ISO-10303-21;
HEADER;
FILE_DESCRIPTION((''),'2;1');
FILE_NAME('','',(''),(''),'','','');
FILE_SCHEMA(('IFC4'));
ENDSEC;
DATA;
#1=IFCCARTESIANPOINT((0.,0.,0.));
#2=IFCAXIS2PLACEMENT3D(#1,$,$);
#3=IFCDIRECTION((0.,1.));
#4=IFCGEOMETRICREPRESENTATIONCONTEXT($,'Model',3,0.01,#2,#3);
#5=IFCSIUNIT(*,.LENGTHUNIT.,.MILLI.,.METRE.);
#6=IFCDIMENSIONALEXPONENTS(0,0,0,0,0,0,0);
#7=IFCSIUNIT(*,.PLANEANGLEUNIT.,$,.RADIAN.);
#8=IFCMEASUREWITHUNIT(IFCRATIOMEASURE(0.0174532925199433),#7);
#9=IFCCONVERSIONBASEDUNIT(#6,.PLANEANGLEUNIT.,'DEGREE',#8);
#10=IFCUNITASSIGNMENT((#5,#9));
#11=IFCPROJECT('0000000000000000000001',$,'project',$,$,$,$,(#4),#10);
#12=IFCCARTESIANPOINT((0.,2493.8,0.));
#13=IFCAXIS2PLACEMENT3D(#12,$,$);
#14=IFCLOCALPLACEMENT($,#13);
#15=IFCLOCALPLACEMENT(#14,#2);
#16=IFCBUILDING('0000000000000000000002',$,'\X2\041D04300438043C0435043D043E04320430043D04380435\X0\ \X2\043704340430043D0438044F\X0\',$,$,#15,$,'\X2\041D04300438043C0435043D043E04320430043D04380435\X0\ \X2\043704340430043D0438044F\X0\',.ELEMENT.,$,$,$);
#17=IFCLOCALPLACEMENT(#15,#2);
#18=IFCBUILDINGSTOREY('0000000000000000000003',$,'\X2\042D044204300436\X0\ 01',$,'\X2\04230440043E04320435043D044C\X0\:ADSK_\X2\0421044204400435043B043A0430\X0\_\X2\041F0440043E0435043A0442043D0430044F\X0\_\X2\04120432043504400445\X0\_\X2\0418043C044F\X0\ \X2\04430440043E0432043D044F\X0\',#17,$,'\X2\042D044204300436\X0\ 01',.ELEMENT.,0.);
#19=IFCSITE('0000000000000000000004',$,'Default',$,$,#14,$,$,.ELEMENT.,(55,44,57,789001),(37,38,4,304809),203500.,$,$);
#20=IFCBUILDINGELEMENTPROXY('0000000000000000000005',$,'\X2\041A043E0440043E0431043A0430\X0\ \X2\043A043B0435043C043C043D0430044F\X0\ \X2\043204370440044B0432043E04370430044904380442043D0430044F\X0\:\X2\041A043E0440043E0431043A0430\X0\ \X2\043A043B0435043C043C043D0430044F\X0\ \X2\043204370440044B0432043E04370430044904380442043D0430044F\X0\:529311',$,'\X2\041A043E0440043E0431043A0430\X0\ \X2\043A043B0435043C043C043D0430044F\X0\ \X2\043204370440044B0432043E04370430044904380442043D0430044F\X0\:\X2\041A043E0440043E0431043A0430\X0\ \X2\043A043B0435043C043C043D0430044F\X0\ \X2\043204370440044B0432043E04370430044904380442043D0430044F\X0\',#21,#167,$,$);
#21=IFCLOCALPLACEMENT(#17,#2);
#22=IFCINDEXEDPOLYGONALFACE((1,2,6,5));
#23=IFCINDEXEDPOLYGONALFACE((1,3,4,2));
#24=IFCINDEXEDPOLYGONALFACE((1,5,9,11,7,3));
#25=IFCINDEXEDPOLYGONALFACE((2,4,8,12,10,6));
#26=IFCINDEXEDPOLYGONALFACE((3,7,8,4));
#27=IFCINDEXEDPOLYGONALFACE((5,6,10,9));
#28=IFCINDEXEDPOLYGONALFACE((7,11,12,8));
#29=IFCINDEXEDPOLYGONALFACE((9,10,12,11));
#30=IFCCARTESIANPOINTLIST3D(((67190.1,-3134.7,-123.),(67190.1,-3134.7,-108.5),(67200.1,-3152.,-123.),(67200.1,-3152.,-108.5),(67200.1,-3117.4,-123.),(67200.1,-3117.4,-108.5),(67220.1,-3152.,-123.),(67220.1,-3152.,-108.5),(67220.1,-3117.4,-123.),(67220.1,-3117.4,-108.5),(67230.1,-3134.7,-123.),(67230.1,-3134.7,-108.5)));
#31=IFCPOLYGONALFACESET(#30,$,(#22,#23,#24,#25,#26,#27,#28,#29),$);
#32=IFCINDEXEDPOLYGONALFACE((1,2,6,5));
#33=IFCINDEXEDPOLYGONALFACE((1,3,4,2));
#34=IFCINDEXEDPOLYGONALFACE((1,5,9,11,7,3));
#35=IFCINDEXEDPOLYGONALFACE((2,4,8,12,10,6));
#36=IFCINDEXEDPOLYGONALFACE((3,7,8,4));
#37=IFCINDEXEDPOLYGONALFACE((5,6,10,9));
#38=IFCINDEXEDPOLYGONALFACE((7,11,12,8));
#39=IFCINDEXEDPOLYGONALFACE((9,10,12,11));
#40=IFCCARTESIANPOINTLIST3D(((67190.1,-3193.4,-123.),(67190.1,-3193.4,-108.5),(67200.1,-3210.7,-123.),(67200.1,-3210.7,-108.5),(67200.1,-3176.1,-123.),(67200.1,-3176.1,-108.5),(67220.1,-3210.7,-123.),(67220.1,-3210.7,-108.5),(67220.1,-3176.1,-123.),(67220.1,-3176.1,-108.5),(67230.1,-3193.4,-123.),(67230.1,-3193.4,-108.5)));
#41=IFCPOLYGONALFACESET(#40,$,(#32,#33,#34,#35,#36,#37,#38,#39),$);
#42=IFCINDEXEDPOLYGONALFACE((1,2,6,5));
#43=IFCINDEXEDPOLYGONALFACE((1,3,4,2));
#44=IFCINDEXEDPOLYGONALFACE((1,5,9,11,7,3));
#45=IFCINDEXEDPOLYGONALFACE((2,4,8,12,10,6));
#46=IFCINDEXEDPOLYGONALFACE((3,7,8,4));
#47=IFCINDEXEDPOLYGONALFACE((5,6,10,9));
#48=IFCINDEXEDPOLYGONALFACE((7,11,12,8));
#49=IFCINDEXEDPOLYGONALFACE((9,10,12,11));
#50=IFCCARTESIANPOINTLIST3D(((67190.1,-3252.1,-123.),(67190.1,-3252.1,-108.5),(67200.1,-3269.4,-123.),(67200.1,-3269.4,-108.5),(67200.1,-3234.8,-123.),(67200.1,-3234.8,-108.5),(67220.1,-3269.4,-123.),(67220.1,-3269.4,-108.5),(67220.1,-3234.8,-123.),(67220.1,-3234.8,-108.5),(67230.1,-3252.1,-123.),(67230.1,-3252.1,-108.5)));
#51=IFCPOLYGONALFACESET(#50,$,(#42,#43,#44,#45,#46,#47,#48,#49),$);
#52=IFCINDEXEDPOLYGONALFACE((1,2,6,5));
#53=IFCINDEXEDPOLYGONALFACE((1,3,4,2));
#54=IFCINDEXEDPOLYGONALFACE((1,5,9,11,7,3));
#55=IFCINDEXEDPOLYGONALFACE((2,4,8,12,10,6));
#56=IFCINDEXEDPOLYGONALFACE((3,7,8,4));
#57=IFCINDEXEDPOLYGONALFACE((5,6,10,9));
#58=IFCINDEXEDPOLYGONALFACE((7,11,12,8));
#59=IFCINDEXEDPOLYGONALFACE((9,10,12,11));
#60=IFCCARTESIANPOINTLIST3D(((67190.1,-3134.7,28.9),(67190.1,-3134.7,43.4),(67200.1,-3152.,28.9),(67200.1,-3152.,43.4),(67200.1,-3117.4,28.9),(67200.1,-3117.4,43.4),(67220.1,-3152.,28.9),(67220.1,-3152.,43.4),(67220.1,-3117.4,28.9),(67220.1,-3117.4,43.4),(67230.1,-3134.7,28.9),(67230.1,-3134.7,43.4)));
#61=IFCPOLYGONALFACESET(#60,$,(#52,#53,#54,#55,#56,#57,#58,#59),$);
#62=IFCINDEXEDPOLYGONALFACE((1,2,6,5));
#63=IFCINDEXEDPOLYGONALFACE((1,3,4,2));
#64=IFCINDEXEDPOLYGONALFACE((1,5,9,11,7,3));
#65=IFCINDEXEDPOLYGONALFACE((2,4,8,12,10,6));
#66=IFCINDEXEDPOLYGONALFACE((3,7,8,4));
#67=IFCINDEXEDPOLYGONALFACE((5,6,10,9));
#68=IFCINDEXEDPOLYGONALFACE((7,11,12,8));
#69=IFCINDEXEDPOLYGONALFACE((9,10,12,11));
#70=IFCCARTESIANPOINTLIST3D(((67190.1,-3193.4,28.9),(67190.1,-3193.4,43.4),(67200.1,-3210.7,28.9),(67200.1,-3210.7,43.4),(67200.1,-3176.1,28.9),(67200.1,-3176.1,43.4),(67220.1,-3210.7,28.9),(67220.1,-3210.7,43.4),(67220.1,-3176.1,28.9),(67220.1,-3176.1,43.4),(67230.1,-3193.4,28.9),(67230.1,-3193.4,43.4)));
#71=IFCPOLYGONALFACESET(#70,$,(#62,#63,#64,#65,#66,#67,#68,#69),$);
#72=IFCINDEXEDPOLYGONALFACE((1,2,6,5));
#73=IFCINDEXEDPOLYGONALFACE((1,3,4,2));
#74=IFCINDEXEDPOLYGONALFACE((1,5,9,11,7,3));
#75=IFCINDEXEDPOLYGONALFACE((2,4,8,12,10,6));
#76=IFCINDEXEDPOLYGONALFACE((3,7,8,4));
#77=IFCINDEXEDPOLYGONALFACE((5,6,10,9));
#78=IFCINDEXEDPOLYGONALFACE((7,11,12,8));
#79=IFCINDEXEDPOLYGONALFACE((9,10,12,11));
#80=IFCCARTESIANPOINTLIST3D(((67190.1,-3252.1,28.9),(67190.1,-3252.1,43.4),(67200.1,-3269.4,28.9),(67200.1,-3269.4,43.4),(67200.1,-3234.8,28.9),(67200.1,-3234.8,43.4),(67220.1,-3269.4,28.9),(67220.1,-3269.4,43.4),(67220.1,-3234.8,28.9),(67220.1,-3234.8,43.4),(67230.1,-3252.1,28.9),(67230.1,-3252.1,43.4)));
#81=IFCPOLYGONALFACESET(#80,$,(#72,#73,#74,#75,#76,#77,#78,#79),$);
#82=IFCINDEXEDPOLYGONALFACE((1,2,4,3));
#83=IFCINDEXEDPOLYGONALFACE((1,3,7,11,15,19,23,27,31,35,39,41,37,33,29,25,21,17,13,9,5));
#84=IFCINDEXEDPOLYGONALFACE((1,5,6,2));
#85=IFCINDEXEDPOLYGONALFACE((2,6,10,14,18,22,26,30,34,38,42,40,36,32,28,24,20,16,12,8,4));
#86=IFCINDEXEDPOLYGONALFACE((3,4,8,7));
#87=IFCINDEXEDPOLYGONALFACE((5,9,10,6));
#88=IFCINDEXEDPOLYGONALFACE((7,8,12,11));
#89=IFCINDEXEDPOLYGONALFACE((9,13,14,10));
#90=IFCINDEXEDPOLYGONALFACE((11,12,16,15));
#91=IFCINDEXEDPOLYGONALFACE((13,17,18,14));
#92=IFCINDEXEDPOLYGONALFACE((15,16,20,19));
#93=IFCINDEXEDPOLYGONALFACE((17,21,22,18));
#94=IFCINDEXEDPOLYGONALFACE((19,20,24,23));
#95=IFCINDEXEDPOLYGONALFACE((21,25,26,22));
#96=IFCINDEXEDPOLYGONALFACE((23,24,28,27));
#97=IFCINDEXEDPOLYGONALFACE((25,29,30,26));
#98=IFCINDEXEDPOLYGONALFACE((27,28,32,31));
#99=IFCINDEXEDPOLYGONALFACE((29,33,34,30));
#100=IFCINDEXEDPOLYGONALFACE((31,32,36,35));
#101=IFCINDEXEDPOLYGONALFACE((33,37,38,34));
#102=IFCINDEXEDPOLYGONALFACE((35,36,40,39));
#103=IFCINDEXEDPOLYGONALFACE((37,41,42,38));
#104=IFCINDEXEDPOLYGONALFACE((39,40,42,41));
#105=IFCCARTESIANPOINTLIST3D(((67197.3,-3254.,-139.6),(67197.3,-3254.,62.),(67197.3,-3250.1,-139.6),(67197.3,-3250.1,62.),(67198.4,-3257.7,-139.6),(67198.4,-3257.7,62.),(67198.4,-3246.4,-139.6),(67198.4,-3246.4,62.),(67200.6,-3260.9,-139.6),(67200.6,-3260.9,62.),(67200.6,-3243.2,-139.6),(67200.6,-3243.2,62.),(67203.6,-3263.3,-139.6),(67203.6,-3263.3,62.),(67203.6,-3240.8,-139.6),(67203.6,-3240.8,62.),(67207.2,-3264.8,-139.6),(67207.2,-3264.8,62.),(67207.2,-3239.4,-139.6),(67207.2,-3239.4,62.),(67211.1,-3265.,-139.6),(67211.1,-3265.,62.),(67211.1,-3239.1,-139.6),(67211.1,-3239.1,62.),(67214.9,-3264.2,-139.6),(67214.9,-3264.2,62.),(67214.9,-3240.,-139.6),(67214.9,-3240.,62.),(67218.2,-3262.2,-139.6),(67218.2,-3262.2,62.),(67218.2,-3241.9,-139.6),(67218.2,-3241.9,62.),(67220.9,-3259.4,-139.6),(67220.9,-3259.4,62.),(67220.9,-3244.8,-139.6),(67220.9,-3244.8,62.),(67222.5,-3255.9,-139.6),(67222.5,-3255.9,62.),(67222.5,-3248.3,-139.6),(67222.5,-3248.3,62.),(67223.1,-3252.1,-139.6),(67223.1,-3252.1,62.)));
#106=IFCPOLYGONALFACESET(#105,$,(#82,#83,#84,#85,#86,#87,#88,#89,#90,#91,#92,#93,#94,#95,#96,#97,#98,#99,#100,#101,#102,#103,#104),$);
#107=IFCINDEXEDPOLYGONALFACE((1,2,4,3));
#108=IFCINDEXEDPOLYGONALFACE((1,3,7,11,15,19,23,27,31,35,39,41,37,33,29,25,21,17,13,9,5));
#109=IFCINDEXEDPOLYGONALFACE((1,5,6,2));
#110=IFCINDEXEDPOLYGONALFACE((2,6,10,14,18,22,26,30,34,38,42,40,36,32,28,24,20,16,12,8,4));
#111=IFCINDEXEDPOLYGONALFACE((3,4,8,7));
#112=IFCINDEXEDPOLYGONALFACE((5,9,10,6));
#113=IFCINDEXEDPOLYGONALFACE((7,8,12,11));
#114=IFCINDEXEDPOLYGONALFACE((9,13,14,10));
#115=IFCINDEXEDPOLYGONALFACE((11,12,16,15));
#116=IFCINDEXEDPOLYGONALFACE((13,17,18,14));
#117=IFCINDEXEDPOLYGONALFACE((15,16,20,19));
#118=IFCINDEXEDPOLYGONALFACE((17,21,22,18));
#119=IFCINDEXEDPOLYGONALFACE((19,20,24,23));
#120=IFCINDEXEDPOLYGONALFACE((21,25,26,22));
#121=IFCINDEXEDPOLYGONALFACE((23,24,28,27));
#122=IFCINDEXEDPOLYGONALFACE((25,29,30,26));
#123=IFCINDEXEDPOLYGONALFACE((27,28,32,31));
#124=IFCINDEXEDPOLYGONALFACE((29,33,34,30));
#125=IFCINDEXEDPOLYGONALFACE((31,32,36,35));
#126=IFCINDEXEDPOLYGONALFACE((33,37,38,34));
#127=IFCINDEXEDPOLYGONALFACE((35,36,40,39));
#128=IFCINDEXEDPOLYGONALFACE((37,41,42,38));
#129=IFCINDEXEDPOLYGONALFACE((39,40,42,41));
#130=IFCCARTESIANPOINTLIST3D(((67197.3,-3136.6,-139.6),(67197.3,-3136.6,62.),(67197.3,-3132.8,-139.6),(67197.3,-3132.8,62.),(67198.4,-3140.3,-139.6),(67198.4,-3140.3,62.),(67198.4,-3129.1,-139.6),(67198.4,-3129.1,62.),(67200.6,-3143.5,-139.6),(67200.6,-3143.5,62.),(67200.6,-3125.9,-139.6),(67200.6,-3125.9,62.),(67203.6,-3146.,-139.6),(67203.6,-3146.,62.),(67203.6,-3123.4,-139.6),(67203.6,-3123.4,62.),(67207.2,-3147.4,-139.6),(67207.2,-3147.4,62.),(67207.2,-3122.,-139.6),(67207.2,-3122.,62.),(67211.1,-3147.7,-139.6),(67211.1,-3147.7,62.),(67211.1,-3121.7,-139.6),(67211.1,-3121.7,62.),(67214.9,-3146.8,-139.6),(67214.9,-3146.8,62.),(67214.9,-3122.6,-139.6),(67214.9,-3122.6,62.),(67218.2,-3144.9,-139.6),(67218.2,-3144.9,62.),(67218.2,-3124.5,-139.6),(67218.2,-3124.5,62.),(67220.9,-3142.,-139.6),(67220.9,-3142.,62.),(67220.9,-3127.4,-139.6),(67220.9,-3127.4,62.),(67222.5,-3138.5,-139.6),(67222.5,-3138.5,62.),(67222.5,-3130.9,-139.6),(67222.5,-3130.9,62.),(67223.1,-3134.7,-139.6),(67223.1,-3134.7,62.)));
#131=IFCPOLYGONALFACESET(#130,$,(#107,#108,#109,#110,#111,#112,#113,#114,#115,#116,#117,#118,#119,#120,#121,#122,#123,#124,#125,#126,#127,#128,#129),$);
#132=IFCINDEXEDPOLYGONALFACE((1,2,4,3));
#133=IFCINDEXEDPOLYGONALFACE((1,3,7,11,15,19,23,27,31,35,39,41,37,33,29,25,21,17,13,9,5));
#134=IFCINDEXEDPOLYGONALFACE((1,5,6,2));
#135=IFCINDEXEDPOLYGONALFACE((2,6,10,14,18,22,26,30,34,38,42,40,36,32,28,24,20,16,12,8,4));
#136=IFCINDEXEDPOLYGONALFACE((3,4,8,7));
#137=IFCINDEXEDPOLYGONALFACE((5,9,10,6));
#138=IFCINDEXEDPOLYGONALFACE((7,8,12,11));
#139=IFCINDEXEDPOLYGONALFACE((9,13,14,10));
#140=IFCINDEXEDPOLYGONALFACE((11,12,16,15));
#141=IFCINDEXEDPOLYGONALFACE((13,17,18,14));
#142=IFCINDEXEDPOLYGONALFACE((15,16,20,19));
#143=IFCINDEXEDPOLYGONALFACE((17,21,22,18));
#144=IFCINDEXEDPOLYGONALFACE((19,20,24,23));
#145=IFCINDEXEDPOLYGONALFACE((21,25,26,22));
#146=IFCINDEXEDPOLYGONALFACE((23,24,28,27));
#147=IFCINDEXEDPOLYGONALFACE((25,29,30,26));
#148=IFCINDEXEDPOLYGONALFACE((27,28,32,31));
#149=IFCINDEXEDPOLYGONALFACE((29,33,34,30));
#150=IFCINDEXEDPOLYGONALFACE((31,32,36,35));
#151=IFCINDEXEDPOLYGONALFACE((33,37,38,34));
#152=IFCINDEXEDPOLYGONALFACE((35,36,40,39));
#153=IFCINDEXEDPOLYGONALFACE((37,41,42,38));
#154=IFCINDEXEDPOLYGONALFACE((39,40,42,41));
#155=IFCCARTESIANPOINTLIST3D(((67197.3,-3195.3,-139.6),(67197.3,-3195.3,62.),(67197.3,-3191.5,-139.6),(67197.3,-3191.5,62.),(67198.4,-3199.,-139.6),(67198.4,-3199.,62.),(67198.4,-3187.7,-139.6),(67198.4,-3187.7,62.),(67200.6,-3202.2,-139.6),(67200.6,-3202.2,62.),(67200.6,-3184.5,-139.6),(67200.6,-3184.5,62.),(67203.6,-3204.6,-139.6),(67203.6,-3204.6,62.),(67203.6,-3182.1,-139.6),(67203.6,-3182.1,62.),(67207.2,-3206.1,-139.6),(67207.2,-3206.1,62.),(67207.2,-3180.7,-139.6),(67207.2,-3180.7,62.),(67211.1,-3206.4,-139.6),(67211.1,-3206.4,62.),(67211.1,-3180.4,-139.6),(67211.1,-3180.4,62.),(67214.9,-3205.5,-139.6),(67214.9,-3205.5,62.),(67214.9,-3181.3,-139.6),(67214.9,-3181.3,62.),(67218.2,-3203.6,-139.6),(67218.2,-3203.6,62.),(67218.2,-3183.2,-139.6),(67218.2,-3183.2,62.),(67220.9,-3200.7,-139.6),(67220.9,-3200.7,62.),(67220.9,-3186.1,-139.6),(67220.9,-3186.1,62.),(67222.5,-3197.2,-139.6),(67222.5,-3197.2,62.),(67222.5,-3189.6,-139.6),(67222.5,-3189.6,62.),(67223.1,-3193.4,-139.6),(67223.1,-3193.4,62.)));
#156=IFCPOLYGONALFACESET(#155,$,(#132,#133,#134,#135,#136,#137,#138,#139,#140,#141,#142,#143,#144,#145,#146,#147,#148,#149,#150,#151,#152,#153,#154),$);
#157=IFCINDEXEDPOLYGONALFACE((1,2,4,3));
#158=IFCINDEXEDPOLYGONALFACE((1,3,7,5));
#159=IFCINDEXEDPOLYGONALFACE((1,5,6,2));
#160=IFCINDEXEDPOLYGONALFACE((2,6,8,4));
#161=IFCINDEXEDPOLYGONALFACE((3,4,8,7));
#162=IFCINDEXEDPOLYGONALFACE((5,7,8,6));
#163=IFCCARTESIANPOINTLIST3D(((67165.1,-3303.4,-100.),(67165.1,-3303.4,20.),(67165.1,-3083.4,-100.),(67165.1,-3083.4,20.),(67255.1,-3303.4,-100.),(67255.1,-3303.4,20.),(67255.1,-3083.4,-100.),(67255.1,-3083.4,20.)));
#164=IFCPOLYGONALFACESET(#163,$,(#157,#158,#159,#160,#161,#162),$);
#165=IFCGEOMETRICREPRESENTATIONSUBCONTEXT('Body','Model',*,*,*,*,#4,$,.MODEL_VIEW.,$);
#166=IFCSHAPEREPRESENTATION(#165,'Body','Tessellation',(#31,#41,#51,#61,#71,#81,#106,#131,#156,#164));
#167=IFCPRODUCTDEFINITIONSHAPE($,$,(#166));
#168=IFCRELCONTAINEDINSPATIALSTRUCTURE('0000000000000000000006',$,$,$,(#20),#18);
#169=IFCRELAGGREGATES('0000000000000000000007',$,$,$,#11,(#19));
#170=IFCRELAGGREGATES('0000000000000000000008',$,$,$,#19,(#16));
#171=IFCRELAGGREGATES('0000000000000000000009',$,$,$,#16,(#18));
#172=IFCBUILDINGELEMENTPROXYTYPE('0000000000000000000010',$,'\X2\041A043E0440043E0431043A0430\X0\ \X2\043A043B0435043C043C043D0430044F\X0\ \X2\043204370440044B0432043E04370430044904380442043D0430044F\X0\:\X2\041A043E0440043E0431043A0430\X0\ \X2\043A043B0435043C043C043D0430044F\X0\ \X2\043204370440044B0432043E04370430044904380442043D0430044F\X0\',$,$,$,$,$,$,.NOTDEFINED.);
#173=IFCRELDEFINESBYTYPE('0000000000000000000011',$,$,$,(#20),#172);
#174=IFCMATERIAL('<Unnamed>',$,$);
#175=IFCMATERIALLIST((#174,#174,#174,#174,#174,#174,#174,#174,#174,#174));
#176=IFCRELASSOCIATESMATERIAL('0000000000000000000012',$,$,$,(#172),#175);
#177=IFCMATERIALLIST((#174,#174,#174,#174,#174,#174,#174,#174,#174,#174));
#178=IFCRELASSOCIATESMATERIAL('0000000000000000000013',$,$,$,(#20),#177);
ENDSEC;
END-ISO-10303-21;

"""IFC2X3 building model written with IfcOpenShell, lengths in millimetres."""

from ifc_helpers import new_model, entity, si_unit, converted_unit, direction, frame, frame_2d, origin, place, context, subcontext, project, spatial, polyline, rectangle, circle, outline, extrude, source, transform, mapped, material, material_list, type_object, type_shapes, element, save


model = new_model("IFC2X3")

# Units and contexts
model_context = context("Model", 3, precision=0.01, world=origin(), true_north=direction((0.0, 1.0)))
body_context = subcontext(model_context, "Body", "Model", "MODEL_VIEW")
ifc_project = project(units=[si_unit("LENGTHUNIT", "METRE", prefix="MILLI"), converted_unit("PLANEANGLEUNIT", "DEGREE", entity("IfcRatioMeasure", 0.0174532925199433), si_unit("PLANEANGLEUNIT", "RADIAN"), dimensions=[0, 0, 0, 0, 0, 0, 0])], contexts=[model_context])

# Site, building, storey
site_placement = place(None, frame((0.0, 2493.8, 0.0)))
site = spatial("IfcSite", under=ifc_project, at=site_placement, Name="Default", CompositionType="ELEMENT", RefLatitude=(55, 44, 57, 789001), RefLongitude=(37, 38, 4, 304809), RefElevation=203500.0)
building_placement = place(site_placement, origin())
building = spatial("IfcBuilding", under=site, at=building_placement, Name="Наименование здания", LongName="Наименование здания", CompositionType="ELEMENT")
storey_placement = place(building_placement, origin())
storey = spatial("IfcBuildingStorey", under=building, at=storey_placement, Name="Этаж 01", ObjectType="Уровень:ADSK_Стрелка_Проектная_Вверх_Имя уровня", LongName="Этаж 01", CompositionType="ELEMENT", Elevation=0.0)

# Building element proxy
ifc_material_1 = material(Name="<Unnamed>")
ifc_material_list_1 = material_list([ifc_material_1, ifc_material_1, ifc_material_1, ifc_material_1, ifc_material_1, ifc_material_1, ifc_material_1, ifc_material_1, ifc_material_1, ifc_material_1])
ifc_material_list_2 = material_list([ifc_material_1, ifc_material_1, ifc_material_1, ifc_material_1, ifc_material_1, ifc_material_1, ifc_material_1, ifc_material_1, ifc_material_1, ifc_material_1])
building_element_proxy_type_1 = type_object("IfcBuildingElementProxyType", Name="Коробка клеммная взрывозащитная:Коробка клеммная взрывозащитная", PredefinedType="NOTDEFINED", material=ifc_material_list_2)
shared_shape_1 = source(origin(), body_context, "Body", "SweptSolid", [
    extrude(outline(polyline([(-10.0, -17.3), (10.0, -17.3), (20.0, 0.0), (10.0, 17.3), (-10.0, 17.3), (-20.0, 0.0), (-10.0, -17.3)])), frame((0.0, 58.7, -23.0), z_axis=(0.0, 0.0, 1.0), x_axis=(-1.0, 0.0, 0.0)), (0.0, 0.0, 1.0), 14.4),
    extrude(outline(polyline([(-10.0, -17.3), (10.0, -17.3), (20.0, 0.0), (10.0, 17.3), (-10.0, 17.3), (-20.0, 0.0), (-10.0, -17.3)])), frame((0.0, 0.0, -23.0), z_axis=(0.0, 0.0, 1.0), x_axis=(-1.0, 0.0, 0.0)), (0.0, 0.0, 1.0), 14.4),
    extrude(outline(polyline([(-10.0, -17.3), (10.0, -17.3), (20.0, 0.0), (10.0, 17.3), (-10.0, 17.3), (-20.0, 0.0), (-10.0, -17.3)])), frame((0.0, -58.7, -23.0), z_axis=(0.0, 0.0, 1.0), x_axis=(-1.0, 0.0, 0.0)), (0.0, 0.0, 1.0), 14.4),
    extrude(outline(polyline([(-10.0, -17.3), (10.0, -17.3), (20.0, 0.0), (10.0, 17.3), (-10.0, 17.3), (-20.0, 0.0), (-10.0, -17.3)])), frame((0.0, 58.7, 128.9), z_axis=(0.0, 0.0, 1.0), x_axis=(-1.0, 0.0, 0.0)), (0.0, 0.0, 1.0), 14.4),
    extrude(outline(polyline([(-10.0, -17.3), (10.0, -17.3), (20.0, 0.0), (10.0, 17.3), (-10.0, 17.3), (-20.0, 0.0), (-10.0, -17.3)])), frame((0.0, 0.0, 128.9), z_axis=(0.0, 0.0, 1.0), x_axis=(-1.0, 0.0, 0.0)), (0.0, 0.0, 1.0), 14.4),
    extrude(outline(polyline([(-10.0, -17.3), (10.0, -17.3), (20.0, 0.0), (10.0, 17.3), (-10.0, 17.3), (-20.0, 0.0), (-10.0, -17.3)])), frame((0.0, -58.7, 128.9), z_axis=(0.0, 0.0, 1.0), x_axis=(-1.0, 0.0, 0.0)), (0.0, 0.0, 1.0), 14.4),
    extrude(circle(Radius=13.0, at=frame_2d((0.0, 0.0), x_axis=(1.0, 0.0))), frame((0.0, -58.7, -39.6)), (0.0, 0.0, 1.0), 201.6),
    extrude(circle(Radius=13.0, at=frame_2d((0.0, 0.0), x_axis=(1.0, 0.0))), frame((0.0, 58.7, -39.6)), (0.0, 0.0, 1.0), 201.6),
    extrude(circle(Radius=13.0, at=frame_2d((0.0, 0.0), x_axis=(1.0, 0.0))), frame((0.0, 0.0, -39.6)), (0.0, 0.0, 1.0), 201.6),
    extrude(rectangle(XDim=220.0, YDim=90.0, at=frame_2d((0.0, 0.0), x_axis=(1.0, 0.0))), frame((0.0, 0.0, 0.0), z_axis=(0.0, 0.0, 1.0), x_axis=(0.0, -1.0, 0.0)), (0.0, 0.0, 1.0), 120.0),
])
type_shapes(building_element_proxy_type_1, [shared_shape_1])
proxy_1_placement = place(storey_placement, frame((67210.1, -3193.4, -100.0)))
element("IfcBuildingElementProxy", 1, at=proxy_1_placement, inside=storey, type_object=building_element_proxy_type_1, material=ifc_material_list_1, Name="Коробка клеммная взрывозащитная:Коробка клеммная взрывозащитная:529311", ObjectType="Коробка клеммная взрывозащитная:Коробка клеммная взрывозащитная", context=body_context, shape_type="MappedRepresentation", body=[
    mapped(shared_shape_1, transform((0.0, 0.0, 0.0), scale=1.0)),
])

save(model, "model.ifc")
